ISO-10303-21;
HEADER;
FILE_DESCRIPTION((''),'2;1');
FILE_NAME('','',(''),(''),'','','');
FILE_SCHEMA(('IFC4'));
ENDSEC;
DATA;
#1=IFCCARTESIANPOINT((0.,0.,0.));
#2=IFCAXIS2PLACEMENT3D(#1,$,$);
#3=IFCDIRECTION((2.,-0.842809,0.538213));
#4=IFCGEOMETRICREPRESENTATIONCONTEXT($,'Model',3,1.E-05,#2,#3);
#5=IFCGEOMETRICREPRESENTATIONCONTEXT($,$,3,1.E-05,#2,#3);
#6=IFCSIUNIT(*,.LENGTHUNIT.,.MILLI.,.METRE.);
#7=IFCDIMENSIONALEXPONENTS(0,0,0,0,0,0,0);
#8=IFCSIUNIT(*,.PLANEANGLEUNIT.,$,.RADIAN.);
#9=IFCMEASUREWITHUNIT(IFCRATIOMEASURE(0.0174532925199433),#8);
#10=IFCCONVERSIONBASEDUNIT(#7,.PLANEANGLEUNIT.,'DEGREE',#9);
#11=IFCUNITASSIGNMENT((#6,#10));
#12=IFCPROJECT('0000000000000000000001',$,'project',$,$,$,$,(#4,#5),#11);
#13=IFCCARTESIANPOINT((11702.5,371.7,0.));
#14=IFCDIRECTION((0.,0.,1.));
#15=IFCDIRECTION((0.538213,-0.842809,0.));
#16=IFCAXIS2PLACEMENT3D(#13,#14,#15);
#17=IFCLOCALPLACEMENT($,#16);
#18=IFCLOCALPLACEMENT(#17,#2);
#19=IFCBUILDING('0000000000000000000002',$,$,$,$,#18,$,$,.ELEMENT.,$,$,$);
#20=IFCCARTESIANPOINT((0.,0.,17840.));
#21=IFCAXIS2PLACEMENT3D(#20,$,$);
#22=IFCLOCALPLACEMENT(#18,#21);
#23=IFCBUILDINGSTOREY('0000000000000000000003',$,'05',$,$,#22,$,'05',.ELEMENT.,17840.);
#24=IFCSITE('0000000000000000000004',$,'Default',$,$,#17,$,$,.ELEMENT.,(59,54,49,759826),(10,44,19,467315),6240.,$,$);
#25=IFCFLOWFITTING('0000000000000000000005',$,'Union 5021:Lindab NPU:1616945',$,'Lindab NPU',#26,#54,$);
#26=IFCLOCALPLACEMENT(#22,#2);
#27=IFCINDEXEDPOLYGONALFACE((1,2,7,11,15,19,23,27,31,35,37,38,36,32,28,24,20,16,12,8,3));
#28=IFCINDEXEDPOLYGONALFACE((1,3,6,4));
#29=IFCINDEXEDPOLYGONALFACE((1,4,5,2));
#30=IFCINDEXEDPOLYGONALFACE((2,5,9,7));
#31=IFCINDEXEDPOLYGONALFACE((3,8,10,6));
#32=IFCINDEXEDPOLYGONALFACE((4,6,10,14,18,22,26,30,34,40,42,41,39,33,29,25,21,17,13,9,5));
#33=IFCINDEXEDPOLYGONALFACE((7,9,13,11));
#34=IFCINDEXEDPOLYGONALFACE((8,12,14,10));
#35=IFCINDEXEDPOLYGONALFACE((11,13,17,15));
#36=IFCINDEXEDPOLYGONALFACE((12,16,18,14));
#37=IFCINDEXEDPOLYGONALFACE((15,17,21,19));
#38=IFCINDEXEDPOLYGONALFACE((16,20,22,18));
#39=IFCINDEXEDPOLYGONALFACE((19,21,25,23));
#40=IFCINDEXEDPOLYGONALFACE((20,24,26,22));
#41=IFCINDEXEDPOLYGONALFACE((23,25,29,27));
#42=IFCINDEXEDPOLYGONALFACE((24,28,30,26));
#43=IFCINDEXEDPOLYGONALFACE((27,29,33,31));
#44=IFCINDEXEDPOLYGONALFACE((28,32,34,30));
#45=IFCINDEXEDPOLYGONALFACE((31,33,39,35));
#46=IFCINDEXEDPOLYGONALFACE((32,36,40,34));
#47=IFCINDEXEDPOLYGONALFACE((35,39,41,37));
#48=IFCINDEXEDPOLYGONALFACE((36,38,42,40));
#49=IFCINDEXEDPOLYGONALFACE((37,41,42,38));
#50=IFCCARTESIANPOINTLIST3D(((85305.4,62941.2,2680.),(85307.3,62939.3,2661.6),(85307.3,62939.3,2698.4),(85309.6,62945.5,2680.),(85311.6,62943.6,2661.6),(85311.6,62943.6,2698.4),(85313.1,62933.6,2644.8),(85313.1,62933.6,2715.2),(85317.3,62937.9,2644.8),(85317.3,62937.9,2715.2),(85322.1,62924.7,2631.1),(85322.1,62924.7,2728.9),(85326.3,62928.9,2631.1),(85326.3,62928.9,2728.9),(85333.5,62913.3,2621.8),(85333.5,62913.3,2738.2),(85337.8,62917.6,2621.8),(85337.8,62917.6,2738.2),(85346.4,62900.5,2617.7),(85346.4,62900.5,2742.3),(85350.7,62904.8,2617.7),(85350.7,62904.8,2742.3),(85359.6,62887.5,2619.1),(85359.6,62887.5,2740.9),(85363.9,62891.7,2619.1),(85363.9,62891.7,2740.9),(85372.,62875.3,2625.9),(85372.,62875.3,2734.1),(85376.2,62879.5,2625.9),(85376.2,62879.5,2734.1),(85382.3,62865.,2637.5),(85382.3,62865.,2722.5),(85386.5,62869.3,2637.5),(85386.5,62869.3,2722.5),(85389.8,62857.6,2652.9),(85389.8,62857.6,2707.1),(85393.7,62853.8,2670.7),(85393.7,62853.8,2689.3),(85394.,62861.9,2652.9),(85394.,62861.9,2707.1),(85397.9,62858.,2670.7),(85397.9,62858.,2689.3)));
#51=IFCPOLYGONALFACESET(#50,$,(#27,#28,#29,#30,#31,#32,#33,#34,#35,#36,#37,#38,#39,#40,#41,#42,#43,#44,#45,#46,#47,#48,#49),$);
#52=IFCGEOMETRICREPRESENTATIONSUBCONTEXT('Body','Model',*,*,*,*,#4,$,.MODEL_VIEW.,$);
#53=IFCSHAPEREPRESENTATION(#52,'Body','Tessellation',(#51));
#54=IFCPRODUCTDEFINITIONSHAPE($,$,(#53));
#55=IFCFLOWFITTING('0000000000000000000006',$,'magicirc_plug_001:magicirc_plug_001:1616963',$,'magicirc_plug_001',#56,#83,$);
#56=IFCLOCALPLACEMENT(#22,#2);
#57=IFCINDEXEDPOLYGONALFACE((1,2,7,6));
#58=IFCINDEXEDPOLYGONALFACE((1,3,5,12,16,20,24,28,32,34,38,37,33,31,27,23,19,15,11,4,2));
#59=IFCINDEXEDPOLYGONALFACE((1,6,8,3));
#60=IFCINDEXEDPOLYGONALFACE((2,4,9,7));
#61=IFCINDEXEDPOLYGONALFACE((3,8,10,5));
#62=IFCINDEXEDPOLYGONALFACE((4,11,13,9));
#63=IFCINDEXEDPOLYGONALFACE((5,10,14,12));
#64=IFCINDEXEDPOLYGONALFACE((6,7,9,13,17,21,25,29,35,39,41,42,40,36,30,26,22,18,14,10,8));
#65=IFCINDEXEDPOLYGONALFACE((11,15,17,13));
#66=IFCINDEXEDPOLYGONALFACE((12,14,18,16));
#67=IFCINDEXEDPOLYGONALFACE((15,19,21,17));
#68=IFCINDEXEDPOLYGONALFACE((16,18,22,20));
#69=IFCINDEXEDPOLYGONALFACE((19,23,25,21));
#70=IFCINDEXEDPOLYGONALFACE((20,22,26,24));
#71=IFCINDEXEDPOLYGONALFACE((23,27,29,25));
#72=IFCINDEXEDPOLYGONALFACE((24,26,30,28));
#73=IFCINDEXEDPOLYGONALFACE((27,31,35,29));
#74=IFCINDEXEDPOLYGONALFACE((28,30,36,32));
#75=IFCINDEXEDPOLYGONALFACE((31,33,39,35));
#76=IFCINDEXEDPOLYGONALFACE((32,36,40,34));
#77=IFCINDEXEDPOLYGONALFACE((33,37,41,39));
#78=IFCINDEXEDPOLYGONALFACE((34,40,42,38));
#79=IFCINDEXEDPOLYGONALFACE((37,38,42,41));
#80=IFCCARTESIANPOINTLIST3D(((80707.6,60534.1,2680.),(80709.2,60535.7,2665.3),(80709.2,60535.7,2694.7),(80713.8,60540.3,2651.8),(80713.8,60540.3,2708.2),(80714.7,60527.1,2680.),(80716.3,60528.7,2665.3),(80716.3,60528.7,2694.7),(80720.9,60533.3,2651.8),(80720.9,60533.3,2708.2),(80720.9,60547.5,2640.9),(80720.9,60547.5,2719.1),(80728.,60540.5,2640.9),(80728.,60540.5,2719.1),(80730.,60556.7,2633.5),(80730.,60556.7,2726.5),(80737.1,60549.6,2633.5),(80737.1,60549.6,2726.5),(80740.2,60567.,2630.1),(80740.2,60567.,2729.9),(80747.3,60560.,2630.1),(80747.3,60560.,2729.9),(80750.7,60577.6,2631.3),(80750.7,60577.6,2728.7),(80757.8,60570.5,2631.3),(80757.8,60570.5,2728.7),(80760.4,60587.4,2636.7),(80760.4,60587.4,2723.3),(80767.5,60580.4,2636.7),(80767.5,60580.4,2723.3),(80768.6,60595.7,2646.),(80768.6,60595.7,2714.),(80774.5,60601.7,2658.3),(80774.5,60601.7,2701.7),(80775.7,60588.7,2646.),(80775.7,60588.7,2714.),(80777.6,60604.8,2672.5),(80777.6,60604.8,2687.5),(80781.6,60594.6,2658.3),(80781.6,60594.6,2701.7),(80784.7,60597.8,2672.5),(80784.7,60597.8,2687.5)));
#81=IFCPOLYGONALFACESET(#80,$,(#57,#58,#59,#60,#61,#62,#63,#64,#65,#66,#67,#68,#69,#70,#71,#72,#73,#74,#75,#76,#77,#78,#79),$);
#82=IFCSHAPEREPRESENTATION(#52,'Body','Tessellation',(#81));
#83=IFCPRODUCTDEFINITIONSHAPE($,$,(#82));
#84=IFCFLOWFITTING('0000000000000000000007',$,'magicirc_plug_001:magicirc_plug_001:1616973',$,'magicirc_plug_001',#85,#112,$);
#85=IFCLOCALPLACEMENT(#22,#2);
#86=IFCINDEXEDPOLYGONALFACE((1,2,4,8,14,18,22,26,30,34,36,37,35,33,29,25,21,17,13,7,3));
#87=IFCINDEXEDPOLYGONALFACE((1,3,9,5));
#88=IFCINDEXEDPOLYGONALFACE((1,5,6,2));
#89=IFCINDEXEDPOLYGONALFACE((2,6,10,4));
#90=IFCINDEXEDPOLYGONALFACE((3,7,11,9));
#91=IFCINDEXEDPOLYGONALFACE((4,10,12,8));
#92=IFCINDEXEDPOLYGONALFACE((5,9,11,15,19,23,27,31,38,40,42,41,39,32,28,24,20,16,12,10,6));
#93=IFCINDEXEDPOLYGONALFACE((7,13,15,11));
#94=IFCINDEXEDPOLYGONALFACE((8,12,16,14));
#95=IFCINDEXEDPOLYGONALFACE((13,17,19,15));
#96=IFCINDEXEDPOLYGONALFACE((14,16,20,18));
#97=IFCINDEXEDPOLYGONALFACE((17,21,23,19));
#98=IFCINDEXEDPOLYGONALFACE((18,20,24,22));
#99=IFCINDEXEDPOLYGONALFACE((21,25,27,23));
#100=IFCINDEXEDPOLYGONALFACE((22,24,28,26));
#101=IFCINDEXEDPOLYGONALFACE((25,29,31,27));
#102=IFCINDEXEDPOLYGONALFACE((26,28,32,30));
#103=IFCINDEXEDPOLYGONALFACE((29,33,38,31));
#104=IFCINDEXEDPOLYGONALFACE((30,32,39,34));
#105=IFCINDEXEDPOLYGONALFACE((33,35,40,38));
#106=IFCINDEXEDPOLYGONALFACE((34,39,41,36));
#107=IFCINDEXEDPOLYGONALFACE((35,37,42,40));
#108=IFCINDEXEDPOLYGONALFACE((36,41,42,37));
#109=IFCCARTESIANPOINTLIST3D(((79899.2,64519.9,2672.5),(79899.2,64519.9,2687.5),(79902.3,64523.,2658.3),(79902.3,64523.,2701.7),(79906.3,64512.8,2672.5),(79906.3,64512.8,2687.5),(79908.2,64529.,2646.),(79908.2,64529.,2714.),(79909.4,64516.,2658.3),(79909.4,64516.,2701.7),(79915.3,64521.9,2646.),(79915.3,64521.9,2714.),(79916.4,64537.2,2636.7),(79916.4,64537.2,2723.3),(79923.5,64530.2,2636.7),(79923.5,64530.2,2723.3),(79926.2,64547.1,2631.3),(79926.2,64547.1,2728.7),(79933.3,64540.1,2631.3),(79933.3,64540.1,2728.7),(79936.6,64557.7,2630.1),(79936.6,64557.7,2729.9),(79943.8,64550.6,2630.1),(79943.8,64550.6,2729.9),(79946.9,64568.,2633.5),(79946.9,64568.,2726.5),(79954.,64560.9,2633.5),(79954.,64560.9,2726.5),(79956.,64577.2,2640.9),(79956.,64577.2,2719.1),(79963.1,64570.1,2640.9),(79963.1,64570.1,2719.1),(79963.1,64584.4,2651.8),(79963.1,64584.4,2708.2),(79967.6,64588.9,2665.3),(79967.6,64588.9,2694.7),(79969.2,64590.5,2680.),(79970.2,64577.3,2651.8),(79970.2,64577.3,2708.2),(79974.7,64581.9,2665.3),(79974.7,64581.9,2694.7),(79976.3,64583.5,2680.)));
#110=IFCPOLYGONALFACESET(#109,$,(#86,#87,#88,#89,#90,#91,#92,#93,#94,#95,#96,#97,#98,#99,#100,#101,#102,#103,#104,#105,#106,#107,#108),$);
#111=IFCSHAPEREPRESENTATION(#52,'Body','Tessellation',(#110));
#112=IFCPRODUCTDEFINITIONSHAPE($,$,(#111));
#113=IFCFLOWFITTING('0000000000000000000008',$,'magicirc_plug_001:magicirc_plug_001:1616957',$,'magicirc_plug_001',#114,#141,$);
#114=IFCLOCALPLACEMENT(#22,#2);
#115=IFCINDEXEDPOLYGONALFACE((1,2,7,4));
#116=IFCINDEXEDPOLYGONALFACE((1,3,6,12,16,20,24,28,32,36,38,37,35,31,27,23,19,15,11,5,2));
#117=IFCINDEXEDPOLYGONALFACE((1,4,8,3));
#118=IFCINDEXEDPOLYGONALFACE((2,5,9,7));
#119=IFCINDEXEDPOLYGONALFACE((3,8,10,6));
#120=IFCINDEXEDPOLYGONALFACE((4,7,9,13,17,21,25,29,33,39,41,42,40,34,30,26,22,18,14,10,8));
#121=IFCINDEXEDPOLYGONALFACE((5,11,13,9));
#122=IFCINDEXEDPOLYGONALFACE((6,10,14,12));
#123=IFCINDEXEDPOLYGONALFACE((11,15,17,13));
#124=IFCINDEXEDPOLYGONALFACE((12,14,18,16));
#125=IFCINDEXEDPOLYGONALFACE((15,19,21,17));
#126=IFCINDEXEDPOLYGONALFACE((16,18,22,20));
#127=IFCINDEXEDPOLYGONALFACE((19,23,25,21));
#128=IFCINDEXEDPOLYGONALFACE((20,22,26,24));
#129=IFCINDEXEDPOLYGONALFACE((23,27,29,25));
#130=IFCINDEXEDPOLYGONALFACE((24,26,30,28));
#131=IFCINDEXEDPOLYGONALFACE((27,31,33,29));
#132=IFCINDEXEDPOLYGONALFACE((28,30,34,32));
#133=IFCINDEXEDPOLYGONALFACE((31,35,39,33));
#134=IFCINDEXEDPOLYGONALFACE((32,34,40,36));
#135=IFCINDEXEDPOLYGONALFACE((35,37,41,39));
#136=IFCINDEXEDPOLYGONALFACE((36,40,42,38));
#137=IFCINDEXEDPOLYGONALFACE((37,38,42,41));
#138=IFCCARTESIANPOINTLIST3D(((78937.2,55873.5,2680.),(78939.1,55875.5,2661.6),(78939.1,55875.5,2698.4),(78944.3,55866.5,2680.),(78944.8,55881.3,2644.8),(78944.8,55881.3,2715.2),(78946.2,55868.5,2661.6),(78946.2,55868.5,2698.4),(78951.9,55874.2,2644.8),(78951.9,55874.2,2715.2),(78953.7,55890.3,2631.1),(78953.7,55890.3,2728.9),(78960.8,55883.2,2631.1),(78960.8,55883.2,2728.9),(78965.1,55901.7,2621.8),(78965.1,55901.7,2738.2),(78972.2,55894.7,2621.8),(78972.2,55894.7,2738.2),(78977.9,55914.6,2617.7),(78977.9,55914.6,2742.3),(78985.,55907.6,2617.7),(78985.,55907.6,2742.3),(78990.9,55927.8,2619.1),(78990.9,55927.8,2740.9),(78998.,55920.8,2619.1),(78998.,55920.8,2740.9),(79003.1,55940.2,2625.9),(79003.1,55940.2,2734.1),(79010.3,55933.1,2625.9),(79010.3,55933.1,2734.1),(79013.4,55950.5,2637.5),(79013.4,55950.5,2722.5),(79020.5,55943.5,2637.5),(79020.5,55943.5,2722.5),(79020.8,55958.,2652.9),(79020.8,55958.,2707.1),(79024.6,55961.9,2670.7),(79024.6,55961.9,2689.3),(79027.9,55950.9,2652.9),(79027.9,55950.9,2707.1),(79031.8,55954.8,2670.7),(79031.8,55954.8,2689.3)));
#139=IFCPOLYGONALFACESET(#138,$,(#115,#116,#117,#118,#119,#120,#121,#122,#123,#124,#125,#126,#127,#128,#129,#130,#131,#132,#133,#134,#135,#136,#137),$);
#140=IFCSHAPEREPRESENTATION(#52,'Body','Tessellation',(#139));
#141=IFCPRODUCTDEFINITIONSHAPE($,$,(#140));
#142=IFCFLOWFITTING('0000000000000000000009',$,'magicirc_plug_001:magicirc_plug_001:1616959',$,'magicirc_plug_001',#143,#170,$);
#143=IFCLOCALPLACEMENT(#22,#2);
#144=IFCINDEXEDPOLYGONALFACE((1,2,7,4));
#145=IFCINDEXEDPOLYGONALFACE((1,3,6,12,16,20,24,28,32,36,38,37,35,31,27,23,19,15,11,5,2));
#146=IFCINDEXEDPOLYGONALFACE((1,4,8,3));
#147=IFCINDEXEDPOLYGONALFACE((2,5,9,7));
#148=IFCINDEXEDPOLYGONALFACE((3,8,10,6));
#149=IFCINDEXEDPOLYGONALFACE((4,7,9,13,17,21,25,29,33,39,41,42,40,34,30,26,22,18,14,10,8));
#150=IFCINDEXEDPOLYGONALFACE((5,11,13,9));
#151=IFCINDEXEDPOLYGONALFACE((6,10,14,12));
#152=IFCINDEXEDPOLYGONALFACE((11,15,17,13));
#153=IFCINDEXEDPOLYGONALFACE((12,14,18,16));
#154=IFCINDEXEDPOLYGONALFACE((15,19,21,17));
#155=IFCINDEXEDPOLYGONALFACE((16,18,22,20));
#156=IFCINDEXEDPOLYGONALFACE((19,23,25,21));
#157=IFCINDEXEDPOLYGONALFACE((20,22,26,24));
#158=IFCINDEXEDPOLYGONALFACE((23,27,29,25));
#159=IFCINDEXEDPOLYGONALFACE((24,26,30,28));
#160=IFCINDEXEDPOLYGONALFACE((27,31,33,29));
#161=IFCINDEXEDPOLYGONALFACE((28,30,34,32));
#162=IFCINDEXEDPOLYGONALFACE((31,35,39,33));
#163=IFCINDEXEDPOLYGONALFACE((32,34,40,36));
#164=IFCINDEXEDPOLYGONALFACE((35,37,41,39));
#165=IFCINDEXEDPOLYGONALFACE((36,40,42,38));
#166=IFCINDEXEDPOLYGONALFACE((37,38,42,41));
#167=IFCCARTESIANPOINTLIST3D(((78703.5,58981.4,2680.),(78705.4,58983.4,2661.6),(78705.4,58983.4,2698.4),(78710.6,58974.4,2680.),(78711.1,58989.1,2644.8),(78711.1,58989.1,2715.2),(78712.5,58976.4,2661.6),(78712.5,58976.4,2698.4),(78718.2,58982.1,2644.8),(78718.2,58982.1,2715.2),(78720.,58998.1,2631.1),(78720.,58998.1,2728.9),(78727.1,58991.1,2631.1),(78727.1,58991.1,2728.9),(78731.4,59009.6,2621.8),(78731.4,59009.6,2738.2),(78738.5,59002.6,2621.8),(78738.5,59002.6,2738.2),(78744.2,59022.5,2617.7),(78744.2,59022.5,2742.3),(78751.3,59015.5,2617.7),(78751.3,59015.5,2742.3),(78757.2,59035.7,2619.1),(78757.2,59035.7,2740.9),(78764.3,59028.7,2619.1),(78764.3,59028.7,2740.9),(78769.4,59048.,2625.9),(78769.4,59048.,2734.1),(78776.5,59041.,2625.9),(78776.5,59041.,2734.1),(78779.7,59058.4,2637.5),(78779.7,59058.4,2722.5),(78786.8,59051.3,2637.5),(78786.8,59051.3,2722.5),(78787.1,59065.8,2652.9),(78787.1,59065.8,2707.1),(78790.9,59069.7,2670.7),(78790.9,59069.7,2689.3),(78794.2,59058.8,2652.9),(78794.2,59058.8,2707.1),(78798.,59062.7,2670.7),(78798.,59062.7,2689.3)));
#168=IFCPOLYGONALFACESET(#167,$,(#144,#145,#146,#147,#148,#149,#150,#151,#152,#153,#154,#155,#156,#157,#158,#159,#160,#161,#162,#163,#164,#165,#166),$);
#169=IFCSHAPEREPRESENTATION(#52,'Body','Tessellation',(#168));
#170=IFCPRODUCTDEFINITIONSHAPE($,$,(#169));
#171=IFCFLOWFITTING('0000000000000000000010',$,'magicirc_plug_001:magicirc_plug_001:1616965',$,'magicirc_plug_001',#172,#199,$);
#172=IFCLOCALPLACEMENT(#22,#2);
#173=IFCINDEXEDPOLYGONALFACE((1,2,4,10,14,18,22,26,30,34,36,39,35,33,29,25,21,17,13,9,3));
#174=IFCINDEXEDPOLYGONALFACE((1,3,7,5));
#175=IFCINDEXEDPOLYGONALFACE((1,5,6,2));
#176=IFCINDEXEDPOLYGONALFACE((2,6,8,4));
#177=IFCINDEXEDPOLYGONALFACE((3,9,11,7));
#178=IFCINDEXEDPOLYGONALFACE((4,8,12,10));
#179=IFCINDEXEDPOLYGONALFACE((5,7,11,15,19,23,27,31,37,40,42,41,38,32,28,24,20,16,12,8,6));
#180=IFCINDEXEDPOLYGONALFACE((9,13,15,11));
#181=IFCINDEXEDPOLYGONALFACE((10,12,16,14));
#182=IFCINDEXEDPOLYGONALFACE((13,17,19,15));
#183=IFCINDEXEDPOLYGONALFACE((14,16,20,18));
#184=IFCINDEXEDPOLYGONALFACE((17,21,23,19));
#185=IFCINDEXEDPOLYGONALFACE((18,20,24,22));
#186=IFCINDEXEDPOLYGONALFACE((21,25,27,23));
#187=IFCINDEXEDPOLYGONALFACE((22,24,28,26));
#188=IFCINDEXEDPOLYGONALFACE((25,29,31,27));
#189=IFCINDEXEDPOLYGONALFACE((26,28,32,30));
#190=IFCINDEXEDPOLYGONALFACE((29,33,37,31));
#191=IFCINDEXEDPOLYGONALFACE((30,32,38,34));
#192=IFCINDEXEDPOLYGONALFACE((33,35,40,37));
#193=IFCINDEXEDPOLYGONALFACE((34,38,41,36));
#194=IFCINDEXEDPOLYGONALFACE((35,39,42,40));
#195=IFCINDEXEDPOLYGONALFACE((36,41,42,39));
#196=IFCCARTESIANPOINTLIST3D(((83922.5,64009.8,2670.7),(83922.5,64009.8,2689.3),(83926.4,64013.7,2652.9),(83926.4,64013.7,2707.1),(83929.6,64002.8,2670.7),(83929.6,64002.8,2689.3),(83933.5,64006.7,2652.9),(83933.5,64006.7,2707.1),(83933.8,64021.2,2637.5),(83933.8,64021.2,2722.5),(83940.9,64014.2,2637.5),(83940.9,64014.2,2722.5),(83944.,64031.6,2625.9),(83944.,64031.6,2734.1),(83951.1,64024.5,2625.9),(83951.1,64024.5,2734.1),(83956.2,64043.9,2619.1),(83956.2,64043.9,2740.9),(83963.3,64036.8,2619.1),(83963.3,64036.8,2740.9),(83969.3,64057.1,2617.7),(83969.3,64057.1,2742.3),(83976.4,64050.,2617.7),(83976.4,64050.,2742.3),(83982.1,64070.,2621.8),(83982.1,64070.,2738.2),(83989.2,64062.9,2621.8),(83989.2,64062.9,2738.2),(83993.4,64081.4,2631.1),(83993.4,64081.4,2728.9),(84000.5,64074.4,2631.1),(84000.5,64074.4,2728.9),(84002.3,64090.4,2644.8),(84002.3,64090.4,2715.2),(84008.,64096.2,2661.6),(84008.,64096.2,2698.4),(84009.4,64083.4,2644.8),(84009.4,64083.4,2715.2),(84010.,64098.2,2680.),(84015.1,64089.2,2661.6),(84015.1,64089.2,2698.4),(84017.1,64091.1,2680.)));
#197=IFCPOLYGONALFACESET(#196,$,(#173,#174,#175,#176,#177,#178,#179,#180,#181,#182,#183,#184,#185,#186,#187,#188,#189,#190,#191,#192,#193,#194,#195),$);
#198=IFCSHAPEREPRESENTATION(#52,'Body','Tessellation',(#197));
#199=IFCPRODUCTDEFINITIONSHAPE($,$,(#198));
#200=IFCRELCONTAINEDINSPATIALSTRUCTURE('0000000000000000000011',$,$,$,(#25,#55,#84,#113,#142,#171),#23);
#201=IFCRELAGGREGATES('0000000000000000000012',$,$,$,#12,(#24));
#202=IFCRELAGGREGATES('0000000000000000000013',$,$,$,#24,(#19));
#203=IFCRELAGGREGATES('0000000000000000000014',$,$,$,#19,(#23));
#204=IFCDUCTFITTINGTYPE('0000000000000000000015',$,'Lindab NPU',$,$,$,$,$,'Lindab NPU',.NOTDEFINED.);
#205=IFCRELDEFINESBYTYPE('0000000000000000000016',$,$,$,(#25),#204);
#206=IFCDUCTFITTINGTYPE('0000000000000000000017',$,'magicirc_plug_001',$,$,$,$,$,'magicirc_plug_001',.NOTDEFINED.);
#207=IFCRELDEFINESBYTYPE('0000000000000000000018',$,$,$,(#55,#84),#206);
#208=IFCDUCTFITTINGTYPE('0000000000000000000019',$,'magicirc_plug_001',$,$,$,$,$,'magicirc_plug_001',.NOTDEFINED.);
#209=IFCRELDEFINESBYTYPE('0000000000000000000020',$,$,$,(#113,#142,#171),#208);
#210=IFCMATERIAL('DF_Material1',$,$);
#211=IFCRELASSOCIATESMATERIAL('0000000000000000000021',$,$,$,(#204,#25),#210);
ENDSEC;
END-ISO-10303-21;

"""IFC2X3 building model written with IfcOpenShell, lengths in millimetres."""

from ifc_helpers import new_model, entity, si_unit, converted_unit, direction, frame, frame_2d, origin, place, context, subcontext, project, spatial, circle, extrude, source, transform, mapped, material, type_object, type_shapes, element, save


model = new_model("IFC2X3")

# Units and contexts
model_context = context("Model", 3, precision=1e-05, world=origin(), true_north=direction((2.0, -0.842809, 0.538213)))
context_of_model = context(None, 3, precision=1e-05, world=origin(), true_north=direction((2.0, -0.842809, 0.538213)))
body_context = subcontext(model_context, "Body", "Model", "MODEL_VIEW")
ifc_project = project(units=[si_unit("LENGTHUNIT", "METRE", prefix="MILLI"), converted_unit("PLANEANGLEUNIT", "DEGREE", entity("IfcRatioMeasure", 0.0174532925199433), si_unit("PLANEANGLEUNIT", "RADIAN"), dimensions=[0, 0, 0, 0, 0, 0, 0])], contexts=[model_context, context_of_model])

# Site, building, storey
site_placement = place(None, frame((11702.5, 371.7, 0.0), z_axis=(0.0, 0.0, 1.0), x_axis=(0.538213, -0.842809, 0.0)))
site = spatial("IfcSite", under=ifc_project, at=site_placement, Name="Default", CompositionType="ELEMENT", RefLatitude=(59, 54, 49, 759826), RefLongitude=(10, 44, 19, 467315), RefElevation=6240.0)
building_placement = place(site_placement, origin())
building = spatial("IfcBuilding", under=site, at=building_placement, CompositionType="ELEMENT")
storey_placement = place(building_placement, frame((0.0, 0.0, 17840.0)))
storey = spatial("IfcBuildingStorey", under=building, at=storey_placement, Name="05", LongName="05", CompositionType="ELEMENT", Elevation=17840.0)

# Shared definitions
ifc_material = material(Name="DF_Material1")

# Flow fittings
duct_fitting_type_1 = type_object("IfcDuctFittingType", Name="Lindab NPU", ElementType="Lindab NPU", PredefinedType="NOTDEFINED", material=ifc_material)
shared_shape_1 = source(origin(), body_context, "Body", "SweptSolid", [
    extrude(circle(Radius=62.5, at=frame_2d((0.0, 0.0), x_axis=(1.0, 0.0))), frame((0.0, 0.0, 0.0), z_axis=(1.0, 0.0, 0.0), x_axis=(0.0, 1.0, 0.0)), (0.0, 0.0, 1.0), 6.0),
])
type_shapes(duct_fitting_type_1, [shared_shape_1])
for number, where, z_axis, x_axis, name in (
    (1, (85349.8, 62897.3, 2680.0), (0.0, 0.0, 1.0), (0.703669, 0.710528, 0.0), "Union 5021:Lindab NPU:1616945"),
):
    element("IfcFlowFitting", number, at=place(storey_placement, frame(where, z_axis=z_axis, x_axis=x_axis)), inside=storey, type_object=duct_fitting_type_1, material=ifc_material, Name=name, ObjectType="Lindab NPU", context=body_context, shape_type="MappedRepresentation", body=[
        mapped(shared_shape_1, transform((0.0, 0.0, 0.0), scale=1.0)),
    ])
duct_fitting_type_2 = type_object("IfcDuctFittingType", Name="magicirc_plug_001", ElementType="magicirc_plug_001", PredefinedType="NOTDEFINED")
shared_shape_2 = source(origin(), body_context, "Body", "SweptSolid", [
    extrude(circle(Radius=50.0, at=frame_2d((0.0, 0.0), x_axis=(1.0, 0.0))), frame((0.0, 0.0, 0.0), z_axis=(1.0, 0.0, 0.0), x_axis=(0.0, 1.0, 0.0)), (0.0, 0.0, 1.0), 10.0),
])
type_shapes(duct_fitting_type_2, [shared_shape_2])
for number, where, z_axis, x_axis, name in (
    (2, (80749.9, 60562.6, 2680.0), (0.0, 0.0, 1.0), (-0.710528, 0.703669, 0.0), "magicirc_plug_001:magicirc_plug_001:1616963"),
    (3, (79934.0, 64555.0, 2680.0), (0.0, 0.0, 1.0), (0.710528, -0.703669, 0.0), "magicirc_plug_001:magicirc_plug_001:1616973"),
):
    element("IfcFlowFitting", number, at=place(storey_placement, frame(where, z_axis=z_axis, x_axis=x_axis)), inside=storey, type_object=duct_fitting_type_2, Name=name, ObjectType="magicirc_plug_001", context=body_context, shape_type="MappedRepresentation", body=[
        mapped(shared_shape_2, transform((0.0, 0.0, 0.0), scale=1.0)),
    ])
duct_fitting_type_3 = type_object("IfcDuctFittingType", Name="magicirc_plug_001", ElementType="magicirc_plug_001", PredefinedType="NOTDEFINED")
shared_shape_3 = source(origin(), body_context, "Body", "SweptSolid", [
    extrude(circle(Radius=62.5, at=frame_2d((0.0, 0.0), x_axis=(1.0, 0.0))), frame((0.0, 0.0, 0.0), z_axis=(1.0, 0.0, 0.0), x_axis=(0.0, 1.0, 0.0)), (0.0, 0.0, 1.0), 10.0),
])
type_shapes(duct_fitting_type_3, [shared_shape_3])
for number, where, z_axis, x_axis, name in (
    (4, (78988.3, 55910.9, 2680.0), (0.0, 0.0, 1.0), (-0.710528, 0.703669, 0.0), "magicirc_plug_001:magicirc_plug_001:1616957"),
    (5, (78754.5, 59018.8, 2680.0), (0.0, 0.0, 1.0), (-0.710528, 0.703669, 0.0), "magicirc_plug_001:magicirc_plug_001:1616959"),
    (6, (83966.0, 64053.8, 2680.0), (0.0, 0.0, 1.0), (0.710528, -0.703669, 0.0), "magicirc_plug_001:magicirc_plug_001:1616965"),
):
    element("IfcFlowFitting", number, at=place(storey_placement, frame(where, z_axis=z_axis, x_axis=x_axis)), inside=storey, type_object=duct_fitting_type_3, Name=name, ObjectType="magicirc_plug_001", context=body_context, shape_type="MappedRepresentation", body=[
        mapped(shared_shape_3, transform((0.0, 0.0, 0.0), scale=1.0)),
    ])

save(model, "model.ifc")
